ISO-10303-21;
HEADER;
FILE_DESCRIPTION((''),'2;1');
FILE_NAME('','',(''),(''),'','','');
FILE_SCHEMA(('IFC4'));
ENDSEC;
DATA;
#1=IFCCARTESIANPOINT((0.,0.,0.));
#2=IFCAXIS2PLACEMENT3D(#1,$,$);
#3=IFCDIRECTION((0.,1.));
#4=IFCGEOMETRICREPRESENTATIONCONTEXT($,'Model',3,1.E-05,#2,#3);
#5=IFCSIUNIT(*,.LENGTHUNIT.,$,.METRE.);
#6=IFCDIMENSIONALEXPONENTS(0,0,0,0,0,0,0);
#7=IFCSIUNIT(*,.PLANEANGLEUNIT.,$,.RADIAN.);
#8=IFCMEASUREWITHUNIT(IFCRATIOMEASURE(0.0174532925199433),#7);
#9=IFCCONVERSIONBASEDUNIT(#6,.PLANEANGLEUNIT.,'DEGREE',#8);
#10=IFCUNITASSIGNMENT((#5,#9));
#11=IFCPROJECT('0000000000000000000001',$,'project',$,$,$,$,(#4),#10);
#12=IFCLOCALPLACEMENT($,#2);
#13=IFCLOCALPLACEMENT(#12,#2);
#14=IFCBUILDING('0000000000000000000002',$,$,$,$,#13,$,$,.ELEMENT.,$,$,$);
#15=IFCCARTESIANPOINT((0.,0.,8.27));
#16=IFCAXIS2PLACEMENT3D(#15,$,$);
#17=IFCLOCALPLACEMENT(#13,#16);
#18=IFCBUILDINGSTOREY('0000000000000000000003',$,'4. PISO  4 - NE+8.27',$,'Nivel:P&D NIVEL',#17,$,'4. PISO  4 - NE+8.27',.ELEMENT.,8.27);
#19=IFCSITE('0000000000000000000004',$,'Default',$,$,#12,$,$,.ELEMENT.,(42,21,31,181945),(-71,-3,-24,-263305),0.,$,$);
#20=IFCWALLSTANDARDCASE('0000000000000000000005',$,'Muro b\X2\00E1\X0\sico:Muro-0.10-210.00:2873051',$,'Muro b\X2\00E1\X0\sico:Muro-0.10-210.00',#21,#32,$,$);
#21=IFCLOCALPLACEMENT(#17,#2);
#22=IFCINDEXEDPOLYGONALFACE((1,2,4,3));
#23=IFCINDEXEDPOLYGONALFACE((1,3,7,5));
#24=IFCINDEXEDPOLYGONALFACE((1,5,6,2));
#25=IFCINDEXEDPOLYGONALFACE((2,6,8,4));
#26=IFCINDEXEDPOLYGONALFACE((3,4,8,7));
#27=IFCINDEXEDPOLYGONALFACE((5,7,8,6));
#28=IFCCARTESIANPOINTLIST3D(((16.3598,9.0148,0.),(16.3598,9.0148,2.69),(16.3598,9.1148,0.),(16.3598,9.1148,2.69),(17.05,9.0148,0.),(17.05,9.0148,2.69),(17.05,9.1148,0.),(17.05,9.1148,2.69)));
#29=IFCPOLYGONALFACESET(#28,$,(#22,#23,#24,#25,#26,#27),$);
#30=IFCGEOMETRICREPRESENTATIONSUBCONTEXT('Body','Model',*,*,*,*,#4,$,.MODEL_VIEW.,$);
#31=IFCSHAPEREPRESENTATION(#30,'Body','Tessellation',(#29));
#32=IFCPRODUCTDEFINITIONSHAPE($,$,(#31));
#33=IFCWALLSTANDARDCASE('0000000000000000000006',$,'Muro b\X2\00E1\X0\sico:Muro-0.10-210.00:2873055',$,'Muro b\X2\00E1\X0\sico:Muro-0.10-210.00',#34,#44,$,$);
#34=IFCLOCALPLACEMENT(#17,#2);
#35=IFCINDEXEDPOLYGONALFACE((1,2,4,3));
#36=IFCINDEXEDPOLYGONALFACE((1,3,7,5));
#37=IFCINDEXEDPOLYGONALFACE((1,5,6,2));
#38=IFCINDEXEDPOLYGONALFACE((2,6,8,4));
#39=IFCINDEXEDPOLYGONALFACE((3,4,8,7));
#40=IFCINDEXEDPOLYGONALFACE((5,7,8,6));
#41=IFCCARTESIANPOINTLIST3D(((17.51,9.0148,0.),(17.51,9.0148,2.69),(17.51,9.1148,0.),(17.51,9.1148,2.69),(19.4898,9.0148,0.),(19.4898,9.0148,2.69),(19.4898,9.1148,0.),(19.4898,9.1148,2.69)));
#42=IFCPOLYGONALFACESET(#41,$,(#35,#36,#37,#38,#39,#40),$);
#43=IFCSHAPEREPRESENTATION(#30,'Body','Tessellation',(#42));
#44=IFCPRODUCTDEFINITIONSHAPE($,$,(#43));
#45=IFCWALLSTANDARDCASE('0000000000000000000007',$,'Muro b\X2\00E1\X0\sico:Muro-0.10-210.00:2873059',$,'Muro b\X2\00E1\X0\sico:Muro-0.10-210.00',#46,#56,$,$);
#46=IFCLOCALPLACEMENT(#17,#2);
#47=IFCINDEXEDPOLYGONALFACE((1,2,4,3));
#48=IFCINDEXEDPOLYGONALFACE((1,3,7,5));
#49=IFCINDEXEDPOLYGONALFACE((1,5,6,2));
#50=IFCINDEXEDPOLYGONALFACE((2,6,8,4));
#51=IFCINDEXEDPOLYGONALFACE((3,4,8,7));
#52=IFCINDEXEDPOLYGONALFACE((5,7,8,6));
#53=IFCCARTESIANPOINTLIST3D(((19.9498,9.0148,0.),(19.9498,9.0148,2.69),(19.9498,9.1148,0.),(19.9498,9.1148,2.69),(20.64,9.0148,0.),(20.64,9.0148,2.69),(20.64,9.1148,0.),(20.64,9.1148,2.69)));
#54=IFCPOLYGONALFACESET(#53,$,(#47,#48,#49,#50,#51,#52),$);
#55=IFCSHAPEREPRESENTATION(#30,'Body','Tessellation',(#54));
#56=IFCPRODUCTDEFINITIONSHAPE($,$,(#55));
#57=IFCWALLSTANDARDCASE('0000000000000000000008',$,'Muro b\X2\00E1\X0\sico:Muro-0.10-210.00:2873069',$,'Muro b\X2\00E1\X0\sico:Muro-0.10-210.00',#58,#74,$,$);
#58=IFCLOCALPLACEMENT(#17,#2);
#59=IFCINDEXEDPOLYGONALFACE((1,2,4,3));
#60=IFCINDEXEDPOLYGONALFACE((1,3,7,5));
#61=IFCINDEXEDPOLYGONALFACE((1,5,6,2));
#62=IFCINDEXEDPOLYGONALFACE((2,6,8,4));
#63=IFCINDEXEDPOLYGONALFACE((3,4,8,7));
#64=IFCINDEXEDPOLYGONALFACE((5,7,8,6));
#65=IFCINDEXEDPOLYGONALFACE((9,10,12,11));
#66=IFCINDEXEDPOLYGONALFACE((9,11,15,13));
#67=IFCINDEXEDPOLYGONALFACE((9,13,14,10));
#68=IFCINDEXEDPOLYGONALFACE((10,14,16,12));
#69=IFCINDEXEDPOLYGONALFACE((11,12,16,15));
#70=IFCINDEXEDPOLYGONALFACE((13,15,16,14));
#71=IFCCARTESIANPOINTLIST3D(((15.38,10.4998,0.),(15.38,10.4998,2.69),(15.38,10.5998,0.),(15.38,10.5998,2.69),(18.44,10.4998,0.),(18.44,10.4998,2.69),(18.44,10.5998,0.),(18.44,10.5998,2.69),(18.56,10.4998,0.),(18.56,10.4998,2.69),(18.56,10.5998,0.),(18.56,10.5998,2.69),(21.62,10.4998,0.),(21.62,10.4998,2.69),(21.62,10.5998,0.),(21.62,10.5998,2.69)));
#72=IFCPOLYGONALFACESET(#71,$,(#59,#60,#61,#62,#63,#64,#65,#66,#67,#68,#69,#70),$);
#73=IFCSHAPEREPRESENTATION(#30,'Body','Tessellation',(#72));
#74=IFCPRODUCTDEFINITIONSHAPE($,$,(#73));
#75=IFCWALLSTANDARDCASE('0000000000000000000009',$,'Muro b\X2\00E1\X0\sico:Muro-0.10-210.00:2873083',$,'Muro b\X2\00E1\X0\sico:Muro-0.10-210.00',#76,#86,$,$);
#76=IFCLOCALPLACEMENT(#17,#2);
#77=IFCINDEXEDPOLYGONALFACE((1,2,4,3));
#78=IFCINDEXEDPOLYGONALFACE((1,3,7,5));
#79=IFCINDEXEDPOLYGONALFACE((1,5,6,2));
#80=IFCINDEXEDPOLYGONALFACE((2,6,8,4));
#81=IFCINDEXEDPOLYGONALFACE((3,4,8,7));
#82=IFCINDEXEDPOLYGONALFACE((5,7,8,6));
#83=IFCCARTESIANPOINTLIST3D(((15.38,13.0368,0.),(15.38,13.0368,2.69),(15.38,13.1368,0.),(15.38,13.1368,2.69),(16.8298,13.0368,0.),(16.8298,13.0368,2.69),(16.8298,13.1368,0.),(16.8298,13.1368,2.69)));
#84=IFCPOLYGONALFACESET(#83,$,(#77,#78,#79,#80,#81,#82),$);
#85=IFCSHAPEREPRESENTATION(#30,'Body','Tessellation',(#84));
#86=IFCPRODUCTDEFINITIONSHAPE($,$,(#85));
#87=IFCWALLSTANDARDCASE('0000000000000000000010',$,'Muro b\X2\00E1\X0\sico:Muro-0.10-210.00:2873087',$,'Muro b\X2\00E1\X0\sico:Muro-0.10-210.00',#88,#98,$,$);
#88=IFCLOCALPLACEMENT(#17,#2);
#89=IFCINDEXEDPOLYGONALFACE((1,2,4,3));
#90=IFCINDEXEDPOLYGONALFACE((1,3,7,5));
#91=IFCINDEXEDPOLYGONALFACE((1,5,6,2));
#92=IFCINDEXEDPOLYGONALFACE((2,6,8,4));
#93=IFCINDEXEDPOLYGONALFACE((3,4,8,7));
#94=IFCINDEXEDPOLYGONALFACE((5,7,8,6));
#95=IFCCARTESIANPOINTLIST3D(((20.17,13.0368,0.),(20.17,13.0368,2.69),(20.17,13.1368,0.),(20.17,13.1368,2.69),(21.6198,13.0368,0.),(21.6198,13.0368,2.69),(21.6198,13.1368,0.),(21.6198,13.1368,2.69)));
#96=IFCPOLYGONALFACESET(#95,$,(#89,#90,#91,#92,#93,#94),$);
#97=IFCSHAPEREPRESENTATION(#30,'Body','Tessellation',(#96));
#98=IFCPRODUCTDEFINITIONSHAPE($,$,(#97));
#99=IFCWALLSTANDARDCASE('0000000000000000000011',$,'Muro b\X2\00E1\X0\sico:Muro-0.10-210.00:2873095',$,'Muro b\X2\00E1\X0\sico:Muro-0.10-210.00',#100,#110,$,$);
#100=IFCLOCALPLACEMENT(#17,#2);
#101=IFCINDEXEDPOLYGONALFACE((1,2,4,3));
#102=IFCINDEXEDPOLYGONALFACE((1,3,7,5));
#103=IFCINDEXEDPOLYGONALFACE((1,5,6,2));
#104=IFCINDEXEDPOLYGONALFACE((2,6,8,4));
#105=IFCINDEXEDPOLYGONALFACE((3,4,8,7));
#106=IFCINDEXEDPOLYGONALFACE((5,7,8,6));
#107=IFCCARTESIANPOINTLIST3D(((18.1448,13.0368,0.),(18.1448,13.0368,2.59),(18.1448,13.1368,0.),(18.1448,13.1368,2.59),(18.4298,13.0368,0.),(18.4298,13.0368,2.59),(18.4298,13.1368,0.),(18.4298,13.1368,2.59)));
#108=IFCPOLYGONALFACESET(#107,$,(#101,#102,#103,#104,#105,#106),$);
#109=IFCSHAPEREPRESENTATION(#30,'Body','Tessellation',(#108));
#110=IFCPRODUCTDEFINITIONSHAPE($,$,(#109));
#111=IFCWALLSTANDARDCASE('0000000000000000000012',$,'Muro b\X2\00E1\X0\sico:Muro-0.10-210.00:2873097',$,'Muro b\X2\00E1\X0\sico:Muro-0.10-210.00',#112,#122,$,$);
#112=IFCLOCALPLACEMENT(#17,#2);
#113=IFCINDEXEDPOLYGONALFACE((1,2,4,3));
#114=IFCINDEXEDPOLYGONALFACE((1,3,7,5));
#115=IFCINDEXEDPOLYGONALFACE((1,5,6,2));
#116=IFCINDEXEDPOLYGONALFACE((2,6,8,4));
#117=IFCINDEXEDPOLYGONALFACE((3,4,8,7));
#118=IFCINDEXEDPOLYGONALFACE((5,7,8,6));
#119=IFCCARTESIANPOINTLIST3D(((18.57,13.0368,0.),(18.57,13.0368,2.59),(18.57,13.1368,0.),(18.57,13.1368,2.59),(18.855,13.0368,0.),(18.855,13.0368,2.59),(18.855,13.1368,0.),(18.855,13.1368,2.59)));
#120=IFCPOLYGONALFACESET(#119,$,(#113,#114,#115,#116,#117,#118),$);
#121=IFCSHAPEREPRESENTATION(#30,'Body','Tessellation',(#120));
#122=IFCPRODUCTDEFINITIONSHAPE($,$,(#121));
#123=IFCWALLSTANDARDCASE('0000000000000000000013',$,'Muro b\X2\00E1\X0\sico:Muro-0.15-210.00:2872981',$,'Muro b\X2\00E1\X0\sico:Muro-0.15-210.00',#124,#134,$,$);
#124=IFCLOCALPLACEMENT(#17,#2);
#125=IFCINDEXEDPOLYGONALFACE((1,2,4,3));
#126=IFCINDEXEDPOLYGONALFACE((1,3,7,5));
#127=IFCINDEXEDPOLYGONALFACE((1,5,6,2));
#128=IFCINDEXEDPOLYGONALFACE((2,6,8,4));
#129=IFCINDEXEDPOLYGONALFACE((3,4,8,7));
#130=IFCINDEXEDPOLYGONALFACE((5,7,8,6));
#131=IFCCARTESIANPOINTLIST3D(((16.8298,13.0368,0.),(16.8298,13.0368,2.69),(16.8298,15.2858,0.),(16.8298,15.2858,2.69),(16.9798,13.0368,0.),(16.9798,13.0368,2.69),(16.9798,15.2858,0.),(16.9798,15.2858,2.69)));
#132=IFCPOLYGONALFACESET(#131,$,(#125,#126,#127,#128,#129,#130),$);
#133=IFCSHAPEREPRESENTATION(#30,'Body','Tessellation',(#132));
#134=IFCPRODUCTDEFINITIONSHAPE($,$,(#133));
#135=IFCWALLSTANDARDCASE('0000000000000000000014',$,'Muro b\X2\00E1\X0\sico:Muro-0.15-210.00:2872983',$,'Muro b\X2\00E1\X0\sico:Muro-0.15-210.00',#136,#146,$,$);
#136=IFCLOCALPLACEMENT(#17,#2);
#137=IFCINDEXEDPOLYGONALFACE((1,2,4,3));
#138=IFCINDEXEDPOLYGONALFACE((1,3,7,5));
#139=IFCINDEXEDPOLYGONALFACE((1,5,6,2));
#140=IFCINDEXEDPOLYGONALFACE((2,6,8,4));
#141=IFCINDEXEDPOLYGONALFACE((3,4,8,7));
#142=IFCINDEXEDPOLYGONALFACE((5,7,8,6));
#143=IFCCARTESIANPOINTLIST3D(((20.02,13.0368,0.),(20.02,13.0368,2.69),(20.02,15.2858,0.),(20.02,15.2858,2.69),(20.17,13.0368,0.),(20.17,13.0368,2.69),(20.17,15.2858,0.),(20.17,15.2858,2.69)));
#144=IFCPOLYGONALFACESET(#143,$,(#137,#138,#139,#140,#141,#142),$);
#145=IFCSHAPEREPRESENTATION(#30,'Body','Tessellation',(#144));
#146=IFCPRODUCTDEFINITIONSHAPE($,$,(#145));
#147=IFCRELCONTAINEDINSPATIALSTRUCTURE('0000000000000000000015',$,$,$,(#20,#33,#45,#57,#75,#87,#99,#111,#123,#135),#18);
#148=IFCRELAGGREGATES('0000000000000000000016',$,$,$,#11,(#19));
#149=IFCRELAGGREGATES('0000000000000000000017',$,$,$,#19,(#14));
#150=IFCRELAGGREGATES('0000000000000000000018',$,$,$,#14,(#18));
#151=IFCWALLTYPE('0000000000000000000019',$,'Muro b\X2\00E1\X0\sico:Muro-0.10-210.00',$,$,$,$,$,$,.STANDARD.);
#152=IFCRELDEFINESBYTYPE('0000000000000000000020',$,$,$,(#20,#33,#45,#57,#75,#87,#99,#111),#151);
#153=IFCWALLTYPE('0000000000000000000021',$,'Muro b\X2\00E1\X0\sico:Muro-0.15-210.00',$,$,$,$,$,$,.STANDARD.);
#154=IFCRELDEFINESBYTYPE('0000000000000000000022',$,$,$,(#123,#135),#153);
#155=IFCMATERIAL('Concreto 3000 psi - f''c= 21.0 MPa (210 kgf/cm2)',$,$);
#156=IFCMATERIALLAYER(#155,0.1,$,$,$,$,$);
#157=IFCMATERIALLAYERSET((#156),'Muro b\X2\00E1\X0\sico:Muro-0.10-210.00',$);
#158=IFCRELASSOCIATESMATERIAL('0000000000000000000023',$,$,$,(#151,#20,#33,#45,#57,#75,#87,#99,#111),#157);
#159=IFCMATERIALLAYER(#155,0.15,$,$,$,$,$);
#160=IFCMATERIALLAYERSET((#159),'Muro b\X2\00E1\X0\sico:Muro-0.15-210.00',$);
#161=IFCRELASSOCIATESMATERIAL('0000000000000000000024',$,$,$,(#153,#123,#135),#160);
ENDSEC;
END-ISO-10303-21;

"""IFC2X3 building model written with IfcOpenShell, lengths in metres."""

from ifc_helpers import new_model, entity, si_unit, converted_unit, direction, frame, frame_2d, origin, place, context, subcontext, project, spatial, rectangle, extrude, material, layer, layer_set, layer_usage, type_object, element, save


model = new_model("IFC2X3")

# Units and contexts
model_context = context("Model", 3, precision=1e-05, world=origin(), true_north=direction((0.0, 1.0)))
body_context = subcontext(model_context, "Body", "Model", "MODEL_VIEW")
ifc_project = project(units=[si_unit("LENGTHUNIT", "METRE"), converted_unit("PLANEANGLEUNIT", "DEGREE", entity("IfcRatioMeasure", 0.0174532925199433), si_unit("PLANEANGLEUNIT", "RADIAN"), dimensions=[0, 0, 0, 0, 0, 0, 0])], contexts=[model_context])

# Site, building, storey
site_placement = place(None, origin())
site = spatial("IfcSite", under=ifc_project, at=site_placement, Name="Default", CompositionType="ELEMENT", RefLatitude=(42, 21, 31, 181945), RefLongitude=(-71, -3, -24, -263305), RefElevation=0.0)
building_placement = place(site_placement, origin())
building = spatial("IfcBuilding", under=site, at=building_placement, CompositionType="ELEMENT")
storey_placement = place(building_placement, frame((0.0, 0.0, 8.27)))
storey = spatial("IfcBuildingStorey", under=building, at=storey_placement, Name="4. PISO  4 - NE+8.27", ObjectType="Nivel:P&D NIVEL", LongName="4. PISO  4 - NE+8.27", CompositionType="ELEMENT", Elevation=8.27)

# Shared definitions
ifc_material = material(Name="Concreto 3000 psi - f'c= 21.0 MPa (210 kgf/cm2)")

# Walls
ifc_layer_1 = layer(ifc_material, 0.1)
ifc_layer_set_1 = layer_set([ifc_layer_1], Name="Muro básico:Muro-0.10-210.00")
ifc_layer_usage_1 = layer_usage(ifc_layer_set_1, "AXIS2", "POSITIVE", -0.05)
wall_type_1 = type_object("IfcWallType", Name="Muro básico:Muro-0.10-210.00", PredefinedType="STANDARD", material=ifc_layer_set_1)
wall_1_placement = place(storey_placement, frame((16.3598, 9.0648, 0.0)))
element("IfcWallStandardCase", 1, at=wall_1_placement, inside=storey, type_object=wall_type_1, material=ifc_layer_usage_1, Name="Muro básico:Muro-0.10-210.00:2873051", ObjectType="Muro básico:Muro-0.10-210.00", context=body_context, shape_type="SweptSolid", body=[
    extrude(rectangle(XDim=0.6902, YDim=0.1, at=frame_2d((0.3451, 0.0), x_axis=(-1.0, 0.0))), origin(), (0.0, 0.0, 1.0), 2.69),
])
wall_2_placement = place(storey_placement, frame((17.51, 9.0648, 0.0)))
element("IfcWallStandardCase", 2, at=wall_2_placement, inside=storey, type_object=wall_type_1, material=ifc_layer_usage_1, Name="Muro básico:Muro-0.10-210.00:2873055", ObjectType="Muro básico:Muro-0.10-210.00", context=body_context, shape_type="SweptSolid", body=[
    extrude(rectangle(XDim=1.9798, YDim=0.1, at=frame_2d((0.9899, 0.0), x_axis=(-1.0, 0.0))), origin(), (0.0, 0.0, 1.0), 2.69),
])
wall_3_placement = place(storey_placement, frame((19.9498, 9.0648, 0.0)))
element("IfcWallStandardCase", 3, at=wall_3_placement, inside=storey, type_object=wall_type_1, material=ifc_layer_usage_1, Name="Muro básico:Muro-0.10-210.00:2873059", ObjectType="Muro básico:Muro-0.10-210.00", context=body_context, shape_type="SweptSolid", body=[
    extrude(rectangle(XDim=0.6902, YDim=0.1, at=frame_2d((0.3451, 0.0), x_axis=(-1.0, 0.0))), origin(), (0.0, 0.0, 1.0), 2.69),
])

# Wall, opening
wall_4_placement = place(storey_placement, frame((15.38, 10.5498, 0.0)))
wall_4 = element("IfcWallStandardCase", 4, at=wall_4_placement, inside=storey, type_object=wall_type_1, material=ifc_layer_usage_1, Name="Muro básico:Muro-0.10-210.00:2873069", ObjectType="Muro básico:Muro-0.10-210.00", context=body_context, shape_type="SweptSolid", body=[
    extrude(rectangle(XDim=6.24, YDim=0.1, at=frame_2d((3.12, 0.0), x_axis=(-1.0, 0.0))), origin(), (0.0, 0.0, 1.0), 2.69),
])
opening_placement = place(storey_placement, frame((15.38, 10.5498, 0.0)))
element("IfcOpeningElement", 5, at=opening_placement, cuts=wall_4, ObjectType="Opening", context=body_context, shape_type="SweptSolid", body=[
    extrude(rectangle(XDim=2.69, YDim=0.1, at=frame_2d((0.0, 0.0), x_axis=(1.0, 0.0))), frame((3.06, 0.0, 1.345), z_axis=(1.0, 0.0, 0.0), x_axis=(0.0, 0.0, -1.0)), (0.0, 0.0, 1.0), 0.12),
])

# Walls
wall_5_placement = place(storey_placement, frame((15.38, 13.0868, 0.0)))
element("IfcWallStandardCase", 6, at=wall_5_placement, inside=storey, type_object=wall_type_1, material=ifc_layer_usage_1, Name="Muro básico:Muro-0.10-210.00:2873083", ObjectType="Muro básico:Muro-0.10-210.00", context=body_context, shape_type="SweptSolid", body=[
    extrude(rectangle(XDim=1.4498, YDim=0.1, at=frame_2d((0.7249, 0.0), x_axis=(-1.0, 0.0))), origin(), (0.0, 0.0, 1.0), 2.69),
])
wall_6_placement = place(storey_placement, frame((20.17, 13.0868, 0.0)))
element("IfcWallStandardCase", 7, at=wall_6_placement, inside=storey, type_object=wall_type_1, material=ifc_layer_usage_1, Name="Muro básico:Muro-0.10-210.00:2873087", ObjectType="Muro básico:Muro-0.10-210.00", context=body_context, shape_type="SweptSolid", body=[
    extrude(rectangle(XDim=1.4498, YDim=0.1, at=frame_2d((0.7249, 0.0), x_axis=(-1.0, 0.0))), origin(), (0.0, 0.0, 1.0), 2.69),
])
wall_7_placement = place(storey_placement, frame((18.1448, 13.0868, 0.0)))
element("IfcWallStandardCase", 8, at=wall_7_placement, inside=storey, type_object=wall_type_1, material=ifc_layer_usage_1, Name="Muro básico:Muro-0.10-210.00:2873095", ObjectType="Muro básico:Muro-0.10-210.00", context=body_context, shape_type="SweptSolid", body=[
    extrude(rectangle(XDim=0.285, YDim=0.1, at=frame_2d((0.1425, 0.0), x_axis=(-1.0, 0.0))), origin(), (0.0, 0.0, 1.0), 2.59),
])
wall_8_placement = place(storey_placement, frame((18.57, 13.0868, 0.0)))
element("IfcWallStandardCase", 9, at=wall_8_placement, inside=storey, type_object=wall_type_1, material=ifc_layer_usage_1, Name="Muro básico:Muro-0.10-210.00:2873097", ObjectType="Muro básico:Muro-0.10-210.00", context=body_context, shape_type="SweptSolid", body=[
    extrude(rectangle(XDim=0.285, YDim=0.1, at=frame_2d((0.1425, 0.0), x_axis=(-1.0, 0.0))), origin(), (0.0, 0.0, 1.0), 2.59),
])
ifc_layer_2 = layer(ifc_material, 0.15)
ifc_layer_set_2 = layer_set([ifc_layer_2], Name="Muro básico:Muro-0.15-210.00")
ifc_layer_usage_2 = layer_usage(ifc_layer_set_2, "AXIS2", "POSITIVE", -0.075)
wall_type_2 = type_object("IfcWallType", Name="Muro básico:Muro-0.15-210.00", PredefinedType="STANDARD", material=ifc_layer_set_2)
for number, where, z_axis, x_axis, name in (
    (10, (16.9048, 13.0368, 0.0), (0.0, 0.0, 1.0), (0.0, 1.0, 0.0), "Muro básico:Muro-0.15-210.00:2872981"),
    (11, (20.095, 13.0368, 0.0), (0.0, 0.0, 1.0), (0.0, 1.0, 0.0), "Muro básico:Muro-0.15-210.00:2872983"),
):
    element("IfcWallStandardCase", number, at=place(storey_placement, frame(where, z_axis=z_axis, x_axis=x_axis)), inside=storey, type_object=wall_type_2, material=ifc_layer_usage_2, Name=name, ObjectType="Muro básico:Muro-0.15-210.00", context=body_context, shape_type="SweptSolid", body=[
        extrude(rectangle(XDim=2.249, YDim=0.15, at=frame_2d((1.1245, 0.0), x_axis=(-1.0, 0.0))), origin(), (0.0, 0.0, 1.0), 2.69),
    ])

save(model, "model.ifc")
